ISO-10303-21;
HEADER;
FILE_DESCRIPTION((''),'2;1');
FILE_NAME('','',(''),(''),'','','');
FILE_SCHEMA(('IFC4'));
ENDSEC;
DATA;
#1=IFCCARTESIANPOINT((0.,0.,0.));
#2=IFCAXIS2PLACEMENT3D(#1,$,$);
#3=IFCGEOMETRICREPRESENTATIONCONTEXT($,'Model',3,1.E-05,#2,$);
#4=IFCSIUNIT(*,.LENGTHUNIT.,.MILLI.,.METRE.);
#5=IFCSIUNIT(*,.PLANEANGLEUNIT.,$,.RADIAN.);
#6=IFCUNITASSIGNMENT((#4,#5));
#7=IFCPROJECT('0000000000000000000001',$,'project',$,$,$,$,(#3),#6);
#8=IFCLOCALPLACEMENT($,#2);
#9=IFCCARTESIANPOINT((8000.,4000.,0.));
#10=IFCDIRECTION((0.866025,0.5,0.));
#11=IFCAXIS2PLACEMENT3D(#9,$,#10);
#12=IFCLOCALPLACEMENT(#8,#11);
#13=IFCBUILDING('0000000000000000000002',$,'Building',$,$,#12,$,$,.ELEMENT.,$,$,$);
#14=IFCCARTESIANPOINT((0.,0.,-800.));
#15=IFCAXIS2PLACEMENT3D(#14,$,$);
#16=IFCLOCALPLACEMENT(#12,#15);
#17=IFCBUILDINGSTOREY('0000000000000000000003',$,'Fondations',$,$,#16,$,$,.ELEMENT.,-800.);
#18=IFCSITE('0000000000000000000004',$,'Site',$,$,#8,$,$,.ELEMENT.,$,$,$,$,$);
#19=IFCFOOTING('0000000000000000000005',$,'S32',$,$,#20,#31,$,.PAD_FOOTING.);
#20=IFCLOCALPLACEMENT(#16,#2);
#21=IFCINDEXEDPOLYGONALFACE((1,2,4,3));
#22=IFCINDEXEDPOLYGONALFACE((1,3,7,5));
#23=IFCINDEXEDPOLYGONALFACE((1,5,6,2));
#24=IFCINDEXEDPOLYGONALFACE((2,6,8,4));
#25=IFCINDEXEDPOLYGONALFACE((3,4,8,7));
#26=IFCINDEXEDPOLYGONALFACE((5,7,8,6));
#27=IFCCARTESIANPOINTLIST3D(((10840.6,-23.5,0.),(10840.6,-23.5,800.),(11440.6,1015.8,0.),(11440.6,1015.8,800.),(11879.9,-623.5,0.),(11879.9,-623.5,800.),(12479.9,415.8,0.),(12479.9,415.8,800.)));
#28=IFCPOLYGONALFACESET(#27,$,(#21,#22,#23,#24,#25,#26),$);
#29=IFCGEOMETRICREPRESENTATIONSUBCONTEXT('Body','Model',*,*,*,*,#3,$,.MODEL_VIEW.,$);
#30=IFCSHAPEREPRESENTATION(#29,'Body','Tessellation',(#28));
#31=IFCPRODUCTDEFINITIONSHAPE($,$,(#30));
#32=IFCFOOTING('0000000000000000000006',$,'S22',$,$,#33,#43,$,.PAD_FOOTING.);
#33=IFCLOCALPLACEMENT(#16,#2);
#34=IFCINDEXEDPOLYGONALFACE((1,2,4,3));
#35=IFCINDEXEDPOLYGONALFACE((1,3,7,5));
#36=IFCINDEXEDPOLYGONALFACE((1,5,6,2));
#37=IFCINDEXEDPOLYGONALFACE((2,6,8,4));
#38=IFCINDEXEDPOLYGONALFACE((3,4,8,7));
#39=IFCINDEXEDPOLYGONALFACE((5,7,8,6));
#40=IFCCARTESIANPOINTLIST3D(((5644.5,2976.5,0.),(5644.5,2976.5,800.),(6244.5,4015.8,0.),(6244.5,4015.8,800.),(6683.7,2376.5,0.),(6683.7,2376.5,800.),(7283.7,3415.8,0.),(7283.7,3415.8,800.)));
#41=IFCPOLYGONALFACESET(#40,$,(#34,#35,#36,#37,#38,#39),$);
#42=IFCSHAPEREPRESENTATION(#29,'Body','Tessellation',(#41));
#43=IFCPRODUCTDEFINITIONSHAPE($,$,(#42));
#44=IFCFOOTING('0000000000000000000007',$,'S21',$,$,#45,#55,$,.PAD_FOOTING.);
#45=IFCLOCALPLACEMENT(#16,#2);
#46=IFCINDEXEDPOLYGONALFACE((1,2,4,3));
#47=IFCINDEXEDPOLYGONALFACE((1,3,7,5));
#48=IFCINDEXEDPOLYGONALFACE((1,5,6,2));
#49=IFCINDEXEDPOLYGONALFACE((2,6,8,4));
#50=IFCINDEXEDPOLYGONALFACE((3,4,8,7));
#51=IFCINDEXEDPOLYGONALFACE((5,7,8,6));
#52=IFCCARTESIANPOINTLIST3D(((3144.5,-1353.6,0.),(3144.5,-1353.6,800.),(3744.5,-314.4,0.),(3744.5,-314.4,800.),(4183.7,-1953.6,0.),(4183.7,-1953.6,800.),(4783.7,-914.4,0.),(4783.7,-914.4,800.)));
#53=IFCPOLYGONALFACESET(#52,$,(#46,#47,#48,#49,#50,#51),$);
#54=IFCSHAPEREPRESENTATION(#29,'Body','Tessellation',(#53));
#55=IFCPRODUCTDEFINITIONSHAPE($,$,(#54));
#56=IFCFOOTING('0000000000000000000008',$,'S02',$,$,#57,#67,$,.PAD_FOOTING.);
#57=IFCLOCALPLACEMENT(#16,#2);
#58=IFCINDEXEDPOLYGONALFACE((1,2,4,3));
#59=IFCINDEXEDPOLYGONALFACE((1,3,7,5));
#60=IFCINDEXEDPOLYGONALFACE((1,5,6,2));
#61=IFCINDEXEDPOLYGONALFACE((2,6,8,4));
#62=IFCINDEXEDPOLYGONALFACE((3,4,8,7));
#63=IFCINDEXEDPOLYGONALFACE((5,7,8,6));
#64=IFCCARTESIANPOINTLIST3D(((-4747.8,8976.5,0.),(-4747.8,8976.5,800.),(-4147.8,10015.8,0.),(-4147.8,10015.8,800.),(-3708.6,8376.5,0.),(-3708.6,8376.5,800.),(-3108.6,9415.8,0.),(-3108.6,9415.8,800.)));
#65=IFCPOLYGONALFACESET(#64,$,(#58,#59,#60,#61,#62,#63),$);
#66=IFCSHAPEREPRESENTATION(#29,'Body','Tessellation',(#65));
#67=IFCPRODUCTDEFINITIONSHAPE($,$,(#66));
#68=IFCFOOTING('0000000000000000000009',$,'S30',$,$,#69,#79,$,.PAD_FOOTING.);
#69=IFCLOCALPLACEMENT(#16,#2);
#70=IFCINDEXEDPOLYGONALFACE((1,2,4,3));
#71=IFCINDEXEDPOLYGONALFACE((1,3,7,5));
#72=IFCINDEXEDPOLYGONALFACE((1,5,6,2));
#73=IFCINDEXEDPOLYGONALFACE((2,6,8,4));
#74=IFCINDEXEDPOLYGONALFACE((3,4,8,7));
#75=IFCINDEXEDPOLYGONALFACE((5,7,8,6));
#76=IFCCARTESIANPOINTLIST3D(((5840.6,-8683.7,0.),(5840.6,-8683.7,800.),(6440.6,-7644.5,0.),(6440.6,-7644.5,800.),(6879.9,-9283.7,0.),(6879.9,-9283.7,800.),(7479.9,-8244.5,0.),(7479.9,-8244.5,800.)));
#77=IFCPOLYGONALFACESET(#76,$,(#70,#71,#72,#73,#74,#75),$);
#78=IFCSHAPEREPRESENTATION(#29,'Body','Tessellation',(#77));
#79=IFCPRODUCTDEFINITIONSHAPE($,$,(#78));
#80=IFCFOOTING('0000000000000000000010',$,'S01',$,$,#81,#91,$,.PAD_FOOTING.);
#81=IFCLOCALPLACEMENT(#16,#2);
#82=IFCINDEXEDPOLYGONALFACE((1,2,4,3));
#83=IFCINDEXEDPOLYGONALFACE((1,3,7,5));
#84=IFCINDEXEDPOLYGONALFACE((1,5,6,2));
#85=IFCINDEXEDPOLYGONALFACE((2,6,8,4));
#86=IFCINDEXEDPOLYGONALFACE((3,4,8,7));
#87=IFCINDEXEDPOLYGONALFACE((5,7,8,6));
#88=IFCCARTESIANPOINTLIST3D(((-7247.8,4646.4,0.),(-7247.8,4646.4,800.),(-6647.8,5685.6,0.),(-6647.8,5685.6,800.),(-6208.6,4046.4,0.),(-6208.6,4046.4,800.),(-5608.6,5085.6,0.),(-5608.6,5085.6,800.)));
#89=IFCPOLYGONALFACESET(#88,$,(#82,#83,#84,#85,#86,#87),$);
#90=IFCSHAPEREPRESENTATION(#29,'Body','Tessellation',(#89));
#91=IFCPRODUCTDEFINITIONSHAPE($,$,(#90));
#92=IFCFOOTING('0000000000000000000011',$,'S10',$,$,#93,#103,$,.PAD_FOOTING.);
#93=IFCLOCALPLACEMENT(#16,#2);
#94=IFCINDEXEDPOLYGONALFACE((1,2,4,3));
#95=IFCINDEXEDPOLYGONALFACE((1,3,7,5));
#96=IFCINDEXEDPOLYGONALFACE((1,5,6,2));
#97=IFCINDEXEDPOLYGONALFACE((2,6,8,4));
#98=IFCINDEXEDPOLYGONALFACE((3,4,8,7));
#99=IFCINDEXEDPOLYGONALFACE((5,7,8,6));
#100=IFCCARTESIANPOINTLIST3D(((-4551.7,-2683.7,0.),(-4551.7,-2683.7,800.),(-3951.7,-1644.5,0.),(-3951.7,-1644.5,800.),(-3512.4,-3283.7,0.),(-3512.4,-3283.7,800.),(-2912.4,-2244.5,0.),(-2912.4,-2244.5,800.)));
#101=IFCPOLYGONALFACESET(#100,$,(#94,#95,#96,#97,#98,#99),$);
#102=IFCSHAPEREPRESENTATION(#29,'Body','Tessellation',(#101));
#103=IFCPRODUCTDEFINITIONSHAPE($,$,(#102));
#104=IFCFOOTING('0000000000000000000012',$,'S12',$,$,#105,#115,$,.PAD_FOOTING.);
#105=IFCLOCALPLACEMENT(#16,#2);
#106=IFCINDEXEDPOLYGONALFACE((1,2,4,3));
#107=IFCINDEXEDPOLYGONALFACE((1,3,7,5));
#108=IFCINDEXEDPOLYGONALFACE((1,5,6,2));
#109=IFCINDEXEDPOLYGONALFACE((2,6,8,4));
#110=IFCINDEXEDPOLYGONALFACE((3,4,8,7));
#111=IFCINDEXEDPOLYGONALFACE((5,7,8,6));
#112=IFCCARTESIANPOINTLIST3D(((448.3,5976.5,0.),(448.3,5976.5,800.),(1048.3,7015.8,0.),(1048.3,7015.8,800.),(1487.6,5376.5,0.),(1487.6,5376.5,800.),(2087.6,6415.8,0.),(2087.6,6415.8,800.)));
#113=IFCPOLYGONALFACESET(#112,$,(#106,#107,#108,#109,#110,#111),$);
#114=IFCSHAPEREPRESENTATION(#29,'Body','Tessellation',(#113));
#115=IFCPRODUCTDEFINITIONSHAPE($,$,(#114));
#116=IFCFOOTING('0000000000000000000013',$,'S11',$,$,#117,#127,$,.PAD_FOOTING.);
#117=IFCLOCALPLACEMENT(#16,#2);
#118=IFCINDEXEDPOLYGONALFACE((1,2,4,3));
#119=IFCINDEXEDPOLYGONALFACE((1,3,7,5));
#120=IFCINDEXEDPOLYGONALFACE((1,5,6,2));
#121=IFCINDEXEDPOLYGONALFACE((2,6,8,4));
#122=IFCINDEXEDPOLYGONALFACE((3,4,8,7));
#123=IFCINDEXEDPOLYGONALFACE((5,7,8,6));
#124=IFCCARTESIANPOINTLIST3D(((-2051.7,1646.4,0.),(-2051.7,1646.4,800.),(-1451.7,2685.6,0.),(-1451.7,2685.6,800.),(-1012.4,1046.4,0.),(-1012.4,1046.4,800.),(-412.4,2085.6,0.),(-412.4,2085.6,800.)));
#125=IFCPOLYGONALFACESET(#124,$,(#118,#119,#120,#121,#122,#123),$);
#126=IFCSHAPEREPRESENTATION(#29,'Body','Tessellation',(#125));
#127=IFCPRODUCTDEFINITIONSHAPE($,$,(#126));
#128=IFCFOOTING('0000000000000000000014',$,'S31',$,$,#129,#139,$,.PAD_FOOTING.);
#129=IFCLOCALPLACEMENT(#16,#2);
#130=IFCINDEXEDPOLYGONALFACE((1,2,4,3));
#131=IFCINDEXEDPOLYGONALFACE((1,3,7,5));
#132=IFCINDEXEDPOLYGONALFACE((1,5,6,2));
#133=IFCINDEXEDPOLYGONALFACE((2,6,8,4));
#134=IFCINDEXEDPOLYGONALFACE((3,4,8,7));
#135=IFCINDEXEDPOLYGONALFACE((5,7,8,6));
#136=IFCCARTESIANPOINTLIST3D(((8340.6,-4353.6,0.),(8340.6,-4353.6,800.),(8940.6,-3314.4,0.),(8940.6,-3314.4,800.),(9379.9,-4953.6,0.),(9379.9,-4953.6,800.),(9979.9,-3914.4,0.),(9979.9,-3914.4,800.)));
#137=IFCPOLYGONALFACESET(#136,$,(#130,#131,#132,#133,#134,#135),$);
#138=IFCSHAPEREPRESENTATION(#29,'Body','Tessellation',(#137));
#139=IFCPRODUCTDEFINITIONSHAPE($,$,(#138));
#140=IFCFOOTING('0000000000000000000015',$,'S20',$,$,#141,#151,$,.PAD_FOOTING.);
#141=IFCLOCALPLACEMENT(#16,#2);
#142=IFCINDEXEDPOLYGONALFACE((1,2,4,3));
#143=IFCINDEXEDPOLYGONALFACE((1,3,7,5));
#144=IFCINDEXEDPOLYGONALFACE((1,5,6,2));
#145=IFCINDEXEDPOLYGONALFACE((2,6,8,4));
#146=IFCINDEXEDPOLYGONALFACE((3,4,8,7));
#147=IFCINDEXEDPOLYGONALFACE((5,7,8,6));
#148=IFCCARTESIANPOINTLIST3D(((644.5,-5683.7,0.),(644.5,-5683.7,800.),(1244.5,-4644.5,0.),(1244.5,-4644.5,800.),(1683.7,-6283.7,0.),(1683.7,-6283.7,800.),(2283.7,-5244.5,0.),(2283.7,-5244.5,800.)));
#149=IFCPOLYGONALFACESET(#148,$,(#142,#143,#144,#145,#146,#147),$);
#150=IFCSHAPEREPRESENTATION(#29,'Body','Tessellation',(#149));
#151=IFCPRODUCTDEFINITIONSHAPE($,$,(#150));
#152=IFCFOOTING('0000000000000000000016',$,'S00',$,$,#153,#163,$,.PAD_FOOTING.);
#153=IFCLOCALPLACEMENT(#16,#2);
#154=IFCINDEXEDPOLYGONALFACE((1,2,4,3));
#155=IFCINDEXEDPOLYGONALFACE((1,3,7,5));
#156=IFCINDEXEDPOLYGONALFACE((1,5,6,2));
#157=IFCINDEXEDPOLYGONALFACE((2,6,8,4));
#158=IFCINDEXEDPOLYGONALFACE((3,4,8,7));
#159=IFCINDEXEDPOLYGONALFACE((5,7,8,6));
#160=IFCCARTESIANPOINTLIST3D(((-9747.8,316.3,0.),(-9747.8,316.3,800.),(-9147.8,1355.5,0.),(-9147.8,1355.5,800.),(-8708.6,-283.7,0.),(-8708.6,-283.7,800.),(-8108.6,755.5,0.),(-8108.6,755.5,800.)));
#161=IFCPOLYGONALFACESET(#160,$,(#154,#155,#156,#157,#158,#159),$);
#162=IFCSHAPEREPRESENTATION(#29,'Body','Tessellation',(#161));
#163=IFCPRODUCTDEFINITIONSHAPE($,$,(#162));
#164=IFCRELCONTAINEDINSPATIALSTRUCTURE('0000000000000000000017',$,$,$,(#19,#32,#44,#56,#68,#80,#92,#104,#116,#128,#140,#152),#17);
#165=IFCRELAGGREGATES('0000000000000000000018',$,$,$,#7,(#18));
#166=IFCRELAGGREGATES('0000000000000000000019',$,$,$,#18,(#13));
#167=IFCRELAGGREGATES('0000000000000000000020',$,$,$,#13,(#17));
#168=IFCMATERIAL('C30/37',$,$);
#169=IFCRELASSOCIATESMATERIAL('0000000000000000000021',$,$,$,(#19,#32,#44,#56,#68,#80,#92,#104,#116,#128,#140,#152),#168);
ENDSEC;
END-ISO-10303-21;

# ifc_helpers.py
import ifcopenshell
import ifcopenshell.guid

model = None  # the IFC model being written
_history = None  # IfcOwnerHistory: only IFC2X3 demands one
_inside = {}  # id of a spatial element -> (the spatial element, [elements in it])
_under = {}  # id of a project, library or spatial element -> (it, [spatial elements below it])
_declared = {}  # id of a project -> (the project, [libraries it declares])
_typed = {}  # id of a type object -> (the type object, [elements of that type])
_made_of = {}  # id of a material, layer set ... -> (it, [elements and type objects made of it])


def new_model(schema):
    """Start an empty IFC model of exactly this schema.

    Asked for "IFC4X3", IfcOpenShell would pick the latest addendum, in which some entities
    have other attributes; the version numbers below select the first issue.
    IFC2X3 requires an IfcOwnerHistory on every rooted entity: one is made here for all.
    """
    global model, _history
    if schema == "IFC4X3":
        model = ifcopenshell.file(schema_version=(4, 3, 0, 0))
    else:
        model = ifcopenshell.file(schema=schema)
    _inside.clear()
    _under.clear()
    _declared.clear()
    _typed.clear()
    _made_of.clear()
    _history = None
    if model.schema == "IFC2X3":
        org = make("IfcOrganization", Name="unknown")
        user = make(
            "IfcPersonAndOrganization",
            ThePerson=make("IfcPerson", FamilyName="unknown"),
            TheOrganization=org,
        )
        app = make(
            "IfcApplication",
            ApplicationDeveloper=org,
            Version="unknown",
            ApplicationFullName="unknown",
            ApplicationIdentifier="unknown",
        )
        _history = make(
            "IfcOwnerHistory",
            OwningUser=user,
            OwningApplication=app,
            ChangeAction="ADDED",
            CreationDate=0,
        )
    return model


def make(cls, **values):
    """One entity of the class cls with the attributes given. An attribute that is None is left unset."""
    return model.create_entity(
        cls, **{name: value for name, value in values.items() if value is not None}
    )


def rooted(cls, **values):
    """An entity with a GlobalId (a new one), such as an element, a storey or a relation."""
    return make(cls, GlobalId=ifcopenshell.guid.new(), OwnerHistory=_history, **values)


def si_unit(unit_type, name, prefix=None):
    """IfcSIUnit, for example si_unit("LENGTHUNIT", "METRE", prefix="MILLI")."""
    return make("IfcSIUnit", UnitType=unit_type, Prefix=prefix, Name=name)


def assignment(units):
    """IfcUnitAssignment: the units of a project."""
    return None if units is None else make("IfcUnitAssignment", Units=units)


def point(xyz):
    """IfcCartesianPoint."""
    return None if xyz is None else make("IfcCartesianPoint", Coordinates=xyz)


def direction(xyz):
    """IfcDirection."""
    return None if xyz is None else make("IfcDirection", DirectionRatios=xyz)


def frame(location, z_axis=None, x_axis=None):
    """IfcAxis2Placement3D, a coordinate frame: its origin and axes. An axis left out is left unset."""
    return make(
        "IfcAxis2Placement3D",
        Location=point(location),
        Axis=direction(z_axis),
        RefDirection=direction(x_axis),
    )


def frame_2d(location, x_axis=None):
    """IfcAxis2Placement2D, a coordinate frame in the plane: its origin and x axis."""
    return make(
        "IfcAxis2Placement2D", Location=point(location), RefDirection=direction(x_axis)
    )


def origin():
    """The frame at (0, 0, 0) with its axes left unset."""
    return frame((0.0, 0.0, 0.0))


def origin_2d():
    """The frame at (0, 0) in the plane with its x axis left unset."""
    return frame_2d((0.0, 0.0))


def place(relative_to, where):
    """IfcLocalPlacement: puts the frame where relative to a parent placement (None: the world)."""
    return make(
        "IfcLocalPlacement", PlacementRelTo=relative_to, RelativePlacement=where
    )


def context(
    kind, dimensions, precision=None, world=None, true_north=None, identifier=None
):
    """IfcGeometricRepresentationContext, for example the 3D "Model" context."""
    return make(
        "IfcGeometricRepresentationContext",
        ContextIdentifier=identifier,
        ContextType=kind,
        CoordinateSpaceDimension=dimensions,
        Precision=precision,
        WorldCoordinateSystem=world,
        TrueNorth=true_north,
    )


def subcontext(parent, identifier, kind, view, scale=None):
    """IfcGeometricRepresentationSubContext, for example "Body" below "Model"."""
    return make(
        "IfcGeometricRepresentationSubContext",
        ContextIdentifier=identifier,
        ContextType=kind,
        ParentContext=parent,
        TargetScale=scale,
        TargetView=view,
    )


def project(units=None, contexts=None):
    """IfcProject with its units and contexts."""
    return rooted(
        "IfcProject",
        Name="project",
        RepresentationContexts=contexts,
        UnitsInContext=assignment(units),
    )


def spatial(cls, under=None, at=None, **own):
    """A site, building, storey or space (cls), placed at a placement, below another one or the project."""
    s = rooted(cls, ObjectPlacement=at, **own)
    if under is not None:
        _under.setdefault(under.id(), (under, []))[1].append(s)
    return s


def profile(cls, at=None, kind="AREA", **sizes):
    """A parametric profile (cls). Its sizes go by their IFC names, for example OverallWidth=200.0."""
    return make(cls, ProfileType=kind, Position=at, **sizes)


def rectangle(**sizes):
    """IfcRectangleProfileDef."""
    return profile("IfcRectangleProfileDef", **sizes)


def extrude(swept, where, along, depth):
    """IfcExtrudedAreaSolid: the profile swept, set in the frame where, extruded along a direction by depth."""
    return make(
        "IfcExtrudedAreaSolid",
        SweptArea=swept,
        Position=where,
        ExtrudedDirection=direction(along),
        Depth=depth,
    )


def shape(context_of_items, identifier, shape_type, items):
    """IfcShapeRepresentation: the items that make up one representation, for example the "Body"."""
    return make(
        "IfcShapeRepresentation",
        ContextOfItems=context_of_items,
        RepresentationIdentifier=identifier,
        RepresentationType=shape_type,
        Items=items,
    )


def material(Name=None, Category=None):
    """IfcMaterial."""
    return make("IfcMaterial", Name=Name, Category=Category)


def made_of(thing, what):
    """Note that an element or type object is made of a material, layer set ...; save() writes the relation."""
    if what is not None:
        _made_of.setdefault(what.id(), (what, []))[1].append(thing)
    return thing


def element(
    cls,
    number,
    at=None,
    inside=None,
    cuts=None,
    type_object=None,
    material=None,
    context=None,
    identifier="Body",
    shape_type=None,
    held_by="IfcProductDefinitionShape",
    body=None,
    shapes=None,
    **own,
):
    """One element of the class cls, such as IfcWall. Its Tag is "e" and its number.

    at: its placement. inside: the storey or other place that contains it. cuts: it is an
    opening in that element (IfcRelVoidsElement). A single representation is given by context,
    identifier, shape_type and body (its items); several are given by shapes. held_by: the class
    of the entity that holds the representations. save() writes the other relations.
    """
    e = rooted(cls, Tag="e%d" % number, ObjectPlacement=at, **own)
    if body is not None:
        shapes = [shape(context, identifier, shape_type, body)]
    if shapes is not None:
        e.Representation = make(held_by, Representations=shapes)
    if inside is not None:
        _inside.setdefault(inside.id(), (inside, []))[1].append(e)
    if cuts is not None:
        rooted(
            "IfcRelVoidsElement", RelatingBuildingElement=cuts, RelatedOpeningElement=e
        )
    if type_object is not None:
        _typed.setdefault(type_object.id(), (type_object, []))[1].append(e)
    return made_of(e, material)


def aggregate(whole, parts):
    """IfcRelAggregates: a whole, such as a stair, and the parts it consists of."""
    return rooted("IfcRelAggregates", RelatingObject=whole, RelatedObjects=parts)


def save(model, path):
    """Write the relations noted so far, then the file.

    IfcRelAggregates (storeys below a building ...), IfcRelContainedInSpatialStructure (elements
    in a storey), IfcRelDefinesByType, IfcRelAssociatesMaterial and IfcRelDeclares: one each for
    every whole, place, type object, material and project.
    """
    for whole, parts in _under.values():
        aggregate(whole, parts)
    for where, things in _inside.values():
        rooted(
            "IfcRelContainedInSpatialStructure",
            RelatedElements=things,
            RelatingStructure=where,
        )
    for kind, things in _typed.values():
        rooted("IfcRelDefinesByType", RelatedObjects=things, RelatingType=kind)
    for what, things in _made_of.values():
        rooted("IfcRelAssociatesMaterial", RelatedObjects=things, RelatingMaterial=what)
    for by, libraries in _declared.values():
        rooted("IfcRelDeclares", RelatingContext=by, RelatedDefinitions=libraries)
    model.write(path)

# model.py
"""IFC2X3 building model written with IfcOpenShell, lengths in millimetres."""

from ifc_helpers import new_model, si_unit, frame, origin, origin_2d, place, context, subcontext, project, spatial, rectangle, extrude, material, element, save


model = new_model("IFC2X3")

# Units and contexts
model_context = context("Model", 3, precision=1e-05, world=origin())
body_context = subcontext(model_context, "Body", "Model", "MODEL_VIEW")
ifc_project = project(units=[si_unit("LENGTHUNIT", "METRE", prefix="MILLI"), si_unit("PLANEANGLEUNIT", "RADIAN")], contexts=[model_context])

# Site, building, storey
site_placement = place(None, origin())
site = spatial("IfcSite", under=ifc_project, at=site_placement, Name="Site", CompositionType="ELEMENT")
building_placement = place(site_placement, frame((8000.0, 4000.0, 0.0), x_axis=(0.866025, 0.5, 0.0)))
building = spatial("IfcBuilding", under=site, at=building_placement, Name="Building", CompositionType="ELEMENT")
storey_placement = place(building_placement, frame((0.0, 0.0, -800.0)))
storey = spatial("IfcBuildingStorey", under=building, at=storey_placement, Name="Fondations", CompositionType="ELEMENT", Elevation=-800.0)

# Footings
ifc_material = material(Name="C30/37")
for number, where, z_axis, x_axis, name in (
    (1, (11660.3, 196.2, 0.0), (0.0, 0.0, 1.0), (0.866025, -0.5, 0.0), "S32"),
    (2, (6464.1, 3196.2, 0.0), (0.0, 0.0, 1.0), (0.866025, -0.5, 0.0), "S22"),
    (3, (3964.1, -1134.0, 0.0), (0.0, 0.0, 1.0), (0.866025, -0.5, 0.0), "S21"),
    (4, (-3928.2, 9196.2, 0.0), (0.0, 0.0, 1.0), (0.866025, -0.5, 0.0), "S02"),
    (5, (6660.3, -8464.1, 0.0), (0.0, 0.0, 1.0), (0.866025, -0.5, 0.0), "S30"),
    (6, (-6428.2, 4866.0, 0.0), (0.0, 0.0, 1.0), (0.866025, -0.5, 0.0), "S01"),
    (7, (-3732.1, -2464.1, 0.0), (0.0, 0.0, 1.0), (0.866025, -0.5, 0.0), "S10"),
    (8, (1267.9, 6196.2, 0.0), (0.0, 0.0, 1.0), (0.866025, -0.5, 0.0), "S12"),
    (9, (-1232.1, 1866.0, 0.0), (0.0, 0.0, 1.0), (0.866025, -0.5, 0.0), "S11"),
    (10, (9160.3, -4134.0, 0.0), (0.0, 0.0, 1.0), (0.866025, -0.5, 0.0), "S31"),
    (11, (1464.1, -5464.1, 0.0), (0.0, 0.0, 1.0), (0.866025, -0.5, 0.0), "S20"),
    (12, (-8928.2, 535.9, 0.0), (0.0, 0.0, 1.0), (0.866025, -0.5, 0.0), "S00"),
):
    element("IfcFooting", number, at=place(storey_placement, frame(where, z_axis=z_axis, x_axis=x_axis)), inside=storey, material=ifc_material, Name=name, PredefinedType="PAD_FOOTING", context=body_context, shape_type="SweptSolid", body=[
        extrude(rectangle(XDim=1200.0, YDim=1200.0, at=origin_2d()), origin(), (0.0, 0.0, 1.0), 800.0),
    ])

save(model, "model.ifc")
